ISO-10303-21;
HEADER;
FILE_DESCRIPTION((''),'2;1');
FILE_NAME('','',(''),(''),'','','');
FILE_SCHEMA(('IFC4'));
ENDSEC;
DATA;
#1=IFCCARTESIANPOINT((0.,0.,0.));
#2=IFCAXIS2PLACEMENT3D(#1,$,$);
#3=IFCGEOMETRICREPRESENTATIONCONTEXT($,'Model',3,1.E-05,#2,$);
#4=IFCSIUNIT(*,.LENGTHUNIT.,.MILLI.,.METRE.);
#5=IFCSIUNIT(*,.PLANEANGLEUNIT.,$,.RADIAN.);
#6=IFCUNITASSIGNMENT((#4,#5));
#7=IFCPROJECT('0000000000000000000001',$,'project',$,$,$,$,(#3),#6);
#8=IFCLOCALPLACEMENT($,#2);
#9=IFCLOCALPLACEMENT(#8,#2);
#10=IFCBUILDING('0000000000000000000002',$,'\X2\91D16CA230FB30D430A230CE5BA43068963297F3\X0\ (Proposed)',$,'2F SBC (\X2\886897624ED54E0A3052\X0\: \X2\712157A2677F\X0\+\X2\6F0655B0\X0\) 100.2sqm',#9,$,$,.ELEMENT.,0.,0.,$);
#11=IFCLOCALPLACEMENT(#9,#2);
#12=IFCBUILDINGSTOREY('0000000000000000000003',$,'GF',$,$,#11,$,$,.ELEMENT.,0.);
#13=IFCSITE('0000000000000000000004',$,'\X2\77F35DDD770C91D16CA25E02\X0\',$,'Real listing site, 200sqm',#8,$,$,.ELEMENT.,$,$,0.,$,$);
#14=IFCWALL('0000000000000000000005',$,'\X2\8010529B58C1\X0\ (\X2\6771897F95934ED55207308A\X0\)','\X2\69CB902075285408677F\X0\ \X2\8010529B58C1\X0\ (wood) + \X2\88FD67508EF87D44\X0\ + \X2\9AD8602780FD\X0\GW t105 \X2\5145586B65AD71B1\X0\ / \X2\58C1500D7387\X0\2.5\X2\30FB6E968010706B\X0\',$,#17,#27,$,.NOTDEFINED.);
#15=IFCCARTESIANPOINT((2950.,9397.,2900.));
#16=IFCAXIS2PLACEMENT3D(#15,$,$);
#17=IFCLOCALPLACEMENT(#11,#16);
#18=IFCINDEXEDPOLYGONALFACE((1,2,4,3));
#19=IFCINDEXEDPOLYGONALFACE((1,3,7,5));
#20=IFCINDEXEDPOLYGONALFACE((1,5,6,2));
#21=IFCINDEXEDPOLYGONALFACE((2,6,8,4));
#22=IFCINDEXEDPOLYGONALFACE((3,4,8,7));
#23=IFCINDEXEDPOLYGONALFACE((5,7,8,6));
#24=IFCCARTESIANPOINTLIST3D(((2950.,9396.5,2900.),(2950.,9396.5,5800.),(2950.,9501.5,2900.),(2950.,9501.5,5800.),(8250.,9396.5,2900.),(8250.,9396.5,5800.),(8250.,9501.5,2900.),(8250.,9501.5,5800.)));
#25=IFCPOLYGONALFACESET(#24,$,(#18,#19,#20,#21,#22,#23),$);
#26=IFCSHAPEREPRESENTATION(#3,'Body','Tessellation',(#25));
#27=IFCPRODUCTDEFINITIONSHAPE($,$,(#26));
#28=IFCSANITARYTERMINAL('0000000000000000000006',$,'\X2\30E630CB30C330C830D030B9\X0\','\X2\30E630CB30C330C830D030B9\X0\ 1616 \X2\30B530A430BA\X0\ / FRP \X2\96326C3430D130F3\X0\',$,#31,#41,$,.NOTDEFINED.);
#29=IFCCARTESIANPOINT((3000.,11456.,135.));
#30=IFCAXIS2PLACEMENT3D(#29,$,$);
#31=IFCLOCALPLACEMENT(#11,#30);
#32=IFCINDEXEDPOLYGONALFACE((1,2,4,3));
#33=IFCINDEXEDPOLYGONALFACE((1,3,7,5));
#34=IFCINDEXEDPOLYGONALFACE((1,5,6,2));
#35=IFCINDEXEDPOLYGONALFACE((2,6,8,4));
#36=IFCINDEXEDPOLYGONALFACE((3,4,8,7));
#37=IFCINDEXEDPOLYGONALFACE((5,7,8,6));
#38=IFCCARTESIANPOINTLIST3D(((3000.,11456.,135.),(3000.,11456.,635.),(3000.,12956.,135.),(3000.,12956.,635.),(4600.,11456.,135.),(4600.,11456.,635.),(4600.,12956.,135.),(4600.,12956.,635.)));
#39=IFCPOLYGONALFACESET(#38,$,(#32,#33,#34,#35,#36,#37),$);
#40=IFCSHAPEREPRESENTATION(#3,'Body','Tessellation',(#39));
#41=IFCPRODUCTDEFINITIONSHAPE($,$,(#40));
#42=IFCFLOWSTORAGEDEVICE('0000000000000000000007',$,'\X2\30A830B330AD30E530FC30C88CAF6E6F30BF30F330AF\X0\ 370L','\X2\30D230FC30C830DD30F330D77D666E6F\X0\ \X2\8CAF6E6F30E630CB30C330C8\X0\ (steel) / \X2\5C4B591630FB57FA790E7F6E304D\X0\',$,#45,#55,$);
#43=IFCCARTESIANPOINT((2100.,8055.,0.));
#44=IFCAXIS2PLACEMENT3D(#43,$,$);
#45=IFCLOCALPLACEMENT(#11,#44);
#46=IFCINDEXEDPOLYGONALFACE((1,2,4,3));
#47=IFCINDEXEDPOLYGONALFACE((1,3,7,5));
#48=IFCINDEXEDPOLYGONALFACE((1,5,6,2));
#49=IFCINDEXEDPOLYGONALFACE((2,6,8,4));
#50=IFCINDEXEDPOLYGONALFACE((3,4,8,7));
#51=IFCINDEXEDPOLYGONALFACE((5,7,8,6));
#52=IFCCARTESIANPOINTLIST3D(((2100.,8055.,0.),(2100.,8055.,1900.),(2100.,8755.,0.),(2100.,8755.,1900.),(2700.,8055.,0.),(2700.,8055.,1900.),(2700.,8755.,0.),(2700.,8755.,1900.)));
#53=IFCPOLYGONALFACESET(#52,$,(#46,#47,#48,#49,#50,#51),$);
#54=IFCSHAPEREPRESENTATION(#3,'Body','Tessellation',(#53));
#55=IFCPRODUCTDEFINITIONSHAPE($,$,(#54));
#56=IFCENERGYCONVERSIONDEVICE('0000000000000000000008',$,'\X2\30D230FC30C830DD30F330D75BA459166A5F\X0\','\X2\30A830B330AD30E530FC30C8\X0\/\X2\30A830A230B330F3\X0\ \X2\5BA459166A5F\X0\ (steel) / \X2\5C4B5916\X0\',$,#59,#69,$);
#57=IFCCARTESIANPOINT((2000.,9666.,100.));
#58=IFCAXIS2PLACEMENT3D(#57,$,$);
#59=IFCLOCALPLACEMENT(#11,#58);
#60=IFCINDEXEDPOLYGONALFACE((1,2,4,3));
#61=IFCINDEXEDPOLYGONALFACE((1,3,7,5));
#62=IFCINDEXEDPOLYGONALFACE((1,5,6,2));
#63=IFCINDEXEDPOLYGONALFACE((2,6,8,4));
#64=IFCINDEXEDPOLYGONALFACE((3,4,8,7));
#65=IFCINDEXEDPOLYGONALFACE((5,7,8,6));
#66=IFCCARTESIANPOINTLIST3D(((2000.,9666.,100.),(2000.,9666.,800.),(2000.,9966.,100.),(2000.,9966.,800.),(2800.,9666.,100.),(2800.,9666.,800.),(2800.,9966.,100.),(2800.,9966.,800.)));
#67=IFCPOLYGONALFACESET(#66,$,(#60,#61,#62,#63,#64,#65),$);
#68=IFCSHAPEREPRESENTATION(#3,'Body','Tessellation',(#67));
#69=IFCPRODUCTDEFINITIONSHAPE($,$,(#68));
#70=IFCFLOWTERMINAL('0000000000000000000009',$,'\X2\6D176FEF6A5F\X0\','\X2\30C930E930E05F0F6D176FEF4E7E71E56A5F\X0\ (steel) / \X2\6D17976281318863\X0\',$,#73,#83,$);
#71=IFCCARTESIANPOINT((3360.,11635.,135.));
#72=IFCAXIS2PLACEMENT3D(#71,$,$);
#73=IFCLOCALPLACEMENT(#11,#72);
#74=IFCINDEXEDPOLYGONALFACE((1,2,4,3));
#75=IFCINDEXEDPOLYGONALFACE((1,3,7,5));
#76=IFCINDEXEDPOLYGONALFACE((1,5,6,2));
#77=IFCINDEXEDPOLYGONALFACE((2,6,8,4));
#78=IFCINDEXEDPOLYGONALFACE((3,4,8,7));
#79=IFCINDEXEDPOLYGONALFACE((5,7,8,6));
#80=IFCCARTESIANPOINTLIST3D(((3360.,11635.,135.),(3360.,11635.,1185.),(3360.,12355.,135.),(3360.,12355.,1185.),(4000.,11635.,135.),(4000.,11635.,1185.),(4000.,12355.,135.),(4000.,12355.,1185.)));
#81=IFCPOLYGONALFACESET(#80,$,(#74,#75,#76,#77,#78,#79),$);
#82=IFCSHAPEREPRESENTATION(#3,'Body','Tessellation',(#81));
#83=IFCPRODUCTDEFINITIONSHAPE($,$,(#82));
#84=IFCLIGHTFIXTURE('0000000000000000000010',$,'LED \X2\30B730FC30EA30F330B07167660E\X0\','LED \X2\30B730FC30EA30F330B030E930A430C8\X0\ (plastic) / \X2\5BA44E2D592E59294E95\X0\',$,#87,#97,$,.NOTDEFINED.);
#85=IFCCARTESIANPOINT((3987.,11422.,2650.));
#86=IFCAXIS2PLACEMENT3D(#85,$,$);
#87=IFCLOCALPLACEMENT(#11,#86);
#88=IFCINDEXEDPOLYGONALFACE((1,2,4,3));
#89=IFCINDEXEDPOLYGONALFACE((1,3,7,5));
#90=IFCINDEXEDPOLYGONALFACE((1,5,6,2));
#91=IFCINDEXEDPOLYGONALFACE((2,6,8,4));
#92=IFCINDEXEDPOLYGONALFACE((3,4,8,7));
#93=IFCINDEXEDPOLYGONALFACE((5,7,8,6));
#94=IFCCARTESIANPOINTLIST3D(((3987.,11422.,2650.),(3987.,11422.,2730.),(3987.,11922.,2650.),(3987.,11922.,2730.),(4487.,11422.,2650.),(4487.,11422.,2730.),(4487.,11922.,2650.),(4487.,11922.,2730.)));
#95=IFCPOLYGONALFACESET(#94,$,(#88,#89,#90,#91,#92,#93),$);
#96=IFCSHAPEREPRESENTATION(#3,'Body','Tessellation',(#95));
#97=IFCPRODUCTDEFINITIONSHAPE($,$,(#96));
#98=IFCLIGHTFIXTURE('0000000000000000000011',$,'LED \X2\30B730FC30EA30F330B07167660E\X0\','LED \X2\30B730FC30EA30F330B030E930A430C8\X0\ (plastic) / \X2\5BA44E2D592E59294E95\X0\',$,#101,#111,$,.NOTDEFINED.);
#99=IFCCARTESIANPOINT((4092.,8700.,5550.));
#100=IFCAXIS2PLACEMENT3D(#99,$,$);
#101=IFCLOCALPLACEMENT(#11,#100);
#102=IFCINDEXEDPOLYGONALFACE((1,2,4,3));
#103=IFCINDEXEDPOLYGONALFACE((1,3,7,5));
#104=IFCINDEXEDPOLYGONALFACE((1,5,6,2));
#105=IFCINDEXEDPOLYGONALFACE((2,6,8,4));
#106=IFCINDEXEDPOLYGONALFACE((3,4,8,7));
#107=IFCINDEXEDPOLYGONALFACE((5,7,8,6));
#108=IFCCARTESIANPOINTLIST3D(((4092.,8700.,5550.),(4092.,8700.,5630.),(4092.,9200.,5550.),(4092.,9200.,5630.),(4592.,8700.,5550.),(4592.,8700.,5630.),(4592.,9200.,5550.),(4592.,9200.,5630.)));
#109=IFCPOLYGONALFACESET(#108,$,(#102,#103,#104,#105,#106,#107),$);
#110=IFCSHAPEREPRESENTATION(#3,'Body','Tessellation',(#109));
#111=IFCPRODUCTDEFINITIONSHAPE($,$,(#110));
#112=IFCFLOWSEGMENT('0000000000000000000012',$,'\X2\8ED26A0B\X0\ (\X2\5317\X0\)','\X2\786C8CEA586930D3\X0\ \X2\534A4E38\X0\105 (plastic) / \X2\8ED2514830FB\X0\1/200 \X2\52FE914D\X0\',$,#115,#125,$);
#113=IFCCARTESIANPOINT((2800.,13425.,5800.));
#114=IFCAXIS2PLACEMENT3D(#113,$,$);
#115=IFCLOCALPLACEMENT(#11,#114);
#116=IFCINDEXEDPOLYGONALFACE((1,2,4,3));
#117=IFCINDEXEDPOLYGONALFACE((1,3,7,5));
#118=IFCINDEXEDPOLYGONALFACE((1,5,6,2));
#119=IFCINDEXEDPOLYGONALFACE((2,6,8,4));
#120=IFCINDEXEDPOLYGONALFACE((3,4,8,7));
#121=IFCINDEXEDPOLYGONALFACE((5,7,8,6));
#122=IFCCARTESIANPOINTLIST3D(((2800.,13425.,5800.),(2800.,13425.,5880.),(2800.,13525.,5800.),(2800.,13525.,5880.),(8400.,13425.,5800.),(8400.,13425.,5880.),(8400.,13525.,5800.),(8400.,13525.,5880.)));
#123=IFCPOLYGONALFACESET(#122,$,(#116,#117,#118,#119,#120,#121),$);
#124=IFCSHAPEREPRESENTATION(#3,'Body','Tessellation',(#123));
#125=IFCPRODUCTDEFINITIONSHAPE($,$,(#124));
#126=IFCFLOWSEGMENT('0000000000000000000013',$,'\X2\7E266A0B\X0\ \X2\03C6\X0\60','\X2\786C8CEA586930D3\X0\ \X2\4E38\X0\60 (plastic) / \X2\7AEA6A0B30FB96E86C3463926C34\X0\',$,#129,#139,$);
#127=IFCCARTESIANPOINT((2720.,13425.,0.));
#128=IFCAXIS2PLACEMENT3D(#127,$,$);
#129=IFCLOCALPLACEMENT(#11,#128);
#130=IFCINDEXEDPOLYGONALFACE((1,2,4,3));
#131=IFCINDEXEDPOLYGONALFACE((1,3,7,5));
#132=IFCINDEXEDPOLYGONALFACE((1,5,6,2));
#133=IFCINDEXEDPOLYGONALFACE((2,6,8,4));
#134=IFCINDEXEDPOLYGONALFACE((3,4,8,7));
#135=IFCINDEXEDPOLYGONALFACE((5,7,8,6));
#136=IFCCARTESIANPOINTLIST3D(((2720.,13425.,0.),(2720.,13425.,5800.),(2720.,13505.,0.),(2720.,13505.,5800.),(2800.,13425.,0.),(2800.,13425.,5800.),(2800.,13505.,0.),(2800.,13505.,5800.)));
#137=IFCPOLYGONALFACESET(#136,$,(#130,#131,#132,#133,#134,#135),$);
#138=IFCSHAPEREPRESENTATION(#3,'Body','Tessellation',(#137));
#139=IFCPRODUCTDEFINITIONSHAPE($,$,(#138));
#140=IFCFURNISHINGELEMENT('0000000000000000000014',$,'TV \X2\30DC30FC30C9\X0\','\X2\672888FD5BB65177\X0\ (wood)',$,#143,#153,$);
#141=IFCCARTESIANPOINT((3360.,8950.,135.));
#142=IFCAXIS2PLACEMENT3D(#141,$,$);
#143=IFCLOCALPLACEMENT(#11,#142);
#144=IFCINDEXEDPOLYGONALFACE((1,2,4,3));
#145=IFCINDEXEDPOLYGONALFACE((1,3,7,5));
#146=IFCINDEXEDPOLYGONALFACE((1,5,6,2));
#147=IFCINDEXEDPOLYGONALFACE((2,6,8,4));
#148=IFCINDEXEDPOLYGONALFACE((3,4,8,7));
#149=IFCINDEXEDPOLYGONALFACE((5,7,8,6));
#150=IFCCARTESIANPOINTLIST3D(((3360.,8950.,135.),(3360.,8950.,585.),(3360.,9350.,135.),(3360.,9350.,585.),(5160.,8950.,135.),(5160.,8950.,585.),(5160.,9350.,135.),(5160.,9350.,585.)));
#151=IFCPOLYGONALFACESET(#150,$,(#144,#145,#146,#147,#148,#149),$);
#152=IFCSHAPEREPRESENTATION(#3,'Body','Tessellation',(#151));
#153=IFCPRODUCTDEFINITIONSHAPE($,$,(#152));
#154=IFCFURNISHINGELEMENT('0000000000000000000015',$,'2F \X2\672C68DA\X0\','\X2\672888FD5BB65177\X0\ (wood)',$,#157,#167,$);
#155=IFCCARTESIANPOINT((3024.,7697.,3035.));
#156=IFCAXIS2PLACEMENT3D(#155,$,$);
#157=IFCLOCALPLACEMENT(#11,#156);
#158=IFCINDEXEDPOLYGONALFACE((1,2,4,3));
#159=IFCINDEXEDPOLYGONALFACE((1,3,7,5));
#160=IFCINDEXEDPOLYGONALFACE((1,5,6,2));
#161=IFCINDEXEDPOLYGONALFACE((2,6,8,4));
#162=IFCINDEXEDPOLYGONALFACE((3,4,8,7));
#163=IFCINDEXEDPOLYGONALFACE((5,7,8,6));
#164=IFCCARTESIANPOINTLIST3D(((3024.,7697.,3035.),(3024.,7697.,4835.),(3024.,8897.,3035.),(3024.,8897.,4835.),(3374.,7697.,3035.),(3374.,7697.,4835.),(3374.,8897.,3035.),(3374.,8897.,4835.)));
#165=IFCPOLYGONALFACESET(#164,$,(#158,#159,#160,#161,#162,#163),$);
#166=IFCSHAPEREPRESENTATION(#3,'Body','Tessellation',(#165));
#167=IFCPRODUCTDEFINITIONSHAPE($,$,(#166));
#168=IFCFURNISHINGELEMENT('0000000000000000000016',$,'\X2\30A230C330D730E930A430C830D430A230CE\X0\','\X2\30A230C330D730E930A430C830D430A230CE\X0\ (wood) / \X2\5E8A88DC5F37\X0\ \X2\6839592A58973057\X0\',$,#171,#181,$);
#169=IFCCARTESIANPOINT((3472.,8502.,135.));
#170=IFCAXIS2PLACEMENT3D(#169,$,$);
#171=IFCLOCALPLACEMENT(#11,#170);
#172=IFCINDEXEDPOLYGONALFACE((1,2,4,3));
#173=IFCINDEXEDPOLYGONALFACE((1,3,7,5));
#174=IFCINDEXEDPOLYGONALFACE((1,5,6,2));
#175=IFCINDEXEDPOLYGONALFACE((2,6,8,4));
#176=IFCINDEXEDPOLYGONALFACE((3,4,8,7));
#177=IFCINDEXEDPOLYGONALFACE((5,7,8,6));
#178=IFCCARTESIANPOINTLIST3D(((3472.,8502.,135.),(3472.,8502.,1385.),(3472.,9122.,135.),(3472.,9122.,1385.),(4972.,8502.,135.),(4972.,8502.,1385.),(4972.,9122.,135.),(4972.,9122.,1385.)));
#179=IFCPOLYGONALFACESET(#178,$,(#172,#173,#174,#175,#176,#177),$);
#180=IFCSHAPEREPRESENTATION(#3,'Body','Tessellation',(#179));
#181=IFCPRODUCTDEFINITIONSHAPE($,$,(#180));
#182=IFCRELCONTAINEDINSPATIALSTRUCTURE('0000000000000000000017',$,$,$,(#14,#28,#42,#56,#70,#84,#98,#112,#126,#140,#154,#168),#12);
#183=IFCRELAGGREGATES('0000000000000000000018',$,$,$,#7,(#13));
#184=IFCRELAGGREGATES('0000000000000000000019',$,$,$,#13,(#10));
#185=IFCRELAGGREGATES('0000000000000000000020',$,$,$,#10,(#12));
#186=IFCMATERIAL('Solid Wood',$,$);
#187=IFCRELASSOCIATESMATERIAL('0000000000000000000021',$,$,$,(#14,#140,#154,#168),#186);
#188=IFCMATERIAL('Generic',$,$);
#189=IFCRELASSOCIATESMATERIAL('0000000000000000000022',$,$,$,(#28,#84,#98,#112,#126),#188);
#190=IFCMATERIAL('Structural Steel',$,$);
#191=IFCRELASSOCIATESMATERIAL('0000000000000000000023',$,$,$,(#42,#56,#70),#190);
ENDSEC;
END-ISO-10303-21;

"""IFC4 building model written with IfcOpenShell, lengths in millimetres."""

from ifc_helpers import new_model, si_unit, frame, frame_2d, origin, place, context, project, spatial, rectangle, extrude, material, element, save


model = new_model("IFC4")

# Units and contexts
model_context = context("Model", 3, precision=1e-05, world=origin())
ifc_project = project(units=[si_unit("LENGTHUNIT", "METRE", prefix="MILLI"), si_unit("PLANEANGLEUNIT", "RADIAN")], contexts=[model_context])

# Site, building, storey
site_placement = place(None, origin())
site = spatial("IfcSite", under=ifc_project, at=site_placement, Name="石川県金沢市", ObjectType="Real listing site, 200sqm", CompositionType="ELEMENT", RefElevation=0.0)
building_placement = place(site_placement, origin())
building = spatial("IfcBuilding", under=site, at=building_placement, Name="金沢・ピアノ室と防音 (Proposed)", ObjectType="2F SBC (表面仕上げ: 無垢板+漆喰) 100.2sqm", CompositionType="ELEMENT", ElevationOfRefHeight=0.0, ElevationOfTerrain=0.0)
storey_placement = place(building_placement, origin())
storey = spatial("IfcBuildingStorey", under=building, at=storey_placement, Name="GF", CompositionType="ELEMENT", Elevation=0.0)

# Shared definitions
ifc_material_1 = material(Name="Solid Wood")

# Wall
wall_1_placement = place(storey_placement, frame((2950.0, 9397.0, 2900.0)))
element("IfcWall", 1, at=wall_1_placement, inside=storey, material=ifc_material_1, Name="耐力壁 (東西間仕切り)", Description="構造用合板 耐力壁 (wood) + 製材軸組 + 高性能GW t105 充填断熱 / 壁倍率2.5・準耐火", PredefinedType="NOTDEFINED", context=model_context, shape_type="SweptSolid", body=[
    extrude(rectangle(XDim=5300.0, YDim=105.0, at=frame_2d((2650.0, 52.0))), frame((2950.0, 9397.0, 2900.0)), (0.0, 0.0, 1.0), 2900.0),
])

# Sanitary terminal
ifc_material_2 = material(Name="Generic")
sanitary_terminal_placement = place(storey_placement, frame((3000.0, 11456.0, 135.0)))
element("IfcSanitaryTerminal", 2, at=sanitary_terminal_placement, inside=storey, material=ifc_material_2, Name="ユニットバス", Description="ユニットバス 1616 サイズ / FRP 防水パン", PredefinedType="NOTDEFINED", context=model_context, shape_type="SweptSolid", body=[
    extrude(rectangle(XDim=1600.0, YDim=1500.0, at=frame_2d((800.0, 750.0))), frame((3000.0, 11456.0, 135.0)), (0.0, 0.0, 1.0), 500.0),
])

# Flow storage device
ifc_material_3 = material(Name="Structural Steel")
flow_storage_device_placement = place(storey_placement, frame((2100.0, 8055.0, 0.0)))
element("IfcFlowStorageDevice", 3, at=flow_storage_device_placement, inside=storey, material=ifc_material_3, Name="エコキュート貯湯タンク 370L", Description="ヒートポンプ給湯 貯湯ユニット (steel) / 屋外・基礎置き", context=model_context, shape_type="SweptSolid", body=[
    extrude(rectangle(XDim=600.0, YDim=700.0, at=frame_2d((300.0, 350.0))), frame((2100.0, 8055.0, 0.0)), (0.0, 0.0, 1.0), 1900.0),
])

# Energy conversion device
energy_conversion_device_placement = place(storey_placement, frame((2000.0, 9666.0, 100.0)))
element("IfcEnergyConversionDevice", 4, at=energy_conversion_device_placement, inside=storey, material=ifc_material_3, Name="ヒートポンプ室外機", Description="エコキュート/エアコン 室外機 (steel) / 屋外", context=model_context, shape_type="SweptSolid", body=[
    extrude(rectangle(XDim=800.0, YDim=300.0, at=frame_2d((400.0, 150.0))), frame((2000.0, 9666.0, 100.0)), (0.0, 0.0, 1.0), 700.0),
])

# Flow terminal
flow_terminal_placement = place(storey_placement, frame((3360.0, 11635.0, 135.0)))
element("IfcFlowTerminal", 5, at=flow_terminal_placement, inside=storey, material=ifc_material_3, Name="洗濯機", Description="ドラム式洗濯乾燥機 (steel) / 洗面脱衣", context=model_context, shape_type="SweptSolid", body=[
    extrude(rectangle(XDim=640.0, YDim=720.0, at=frame_2d((320.0, 360.0))), frame((3360.0, 11635.0, 135.0)), (0.0, 0.0, 1.0), 1050.0),
])

# Light fixtures
light_fixture_1_placement = place(storey_placement, frame((3987.0, 11422.0, 2650.0)))
element("IfcLightFixture", 6, at=light_fixture_1_placement, inside=storey, material=ifc_material_2, Name="LED シーリング照明", Description="LED シーリングライト (plastic) / 室中央天井", PredefinedType="NOTDEFINED", context=model_context, shape_type="SweptSolid", body=[
    extrude(rectangle(XDim=500.0, YDim=500.0, at=frame_2d((250.0, 250.0))), frame((3987.0, 11422.0, 2650.0)), (0.0, 0.0, 1.0), 80.0),
])
light_fixture_2_placement = place(storey_placement, frame((4092.0, 8700.0, 5550.0)))
element("IfcLightFixture", 7, at=light_fixture_2_placement, inside=storey, material=ifc_material_2, Name="LED シーリング照明", Description="LED シーリングライト (plastic) / 室中央天井", PredefinedType="NOTDEFINED", context=model_context, shape_type="SweptSolid", body=[
    extrude(rectangle(XDim=500.0, YDim=500.0, at=frame_2d((250.0, 250.0))), frame((4092.0, 8700.0, 5550.0)), (0.0, 0.0, 1.0), 80.0),
])

# Flow segments
flow_segment_1_placement = place(storey_placement, frame((2800.0, 13425.0, 5800.0)))
element("IfcFlowSegment", 8, at=flow_segment_1_placement, inside=storey, material=ifc_material_2, Name="軒樋 (北)", Description="硬質塩ビ 半丸105 (plastic) / 軒先・1/200 勾配", context=model_context, shape_type="SweptSolid", body=[
    extrude(rectangle(XDim=5600.0, YDim=100.0, at=frame_2d((2800.0, 50.0))), frame((2800.0, 13425.0, 5800.0)), (0.0, 0.0, 1.0), 80.0),
])
flow_segment_2_placement = place(storey_placement, frame((2720.0, 13425.0, 0.0)))
element("IfcFlowSegment", 9, at=flow_segment_2_placement, inside=storey, material=ifc_material_2, Name="縦樋 φ60", Description="硬質塩ビ 丸60 (plastic) / 竪樋・雨水排水", context=model_context, shape_type="SweptSolid", body=[
    extrude(rectangle(XDim=80.0, YDim=80.0, at=frame_2d((40.0, 40.0))), frame((2720.0, 13425.0, 0.0)), (0.0, 0.0, 1.0), 5800.0),
])

# Furnishing elements
furnishing_1_placement = place(storey_placement, frame((3360.0, 8950.0, 135.0)))
element("IfcFurnishingElement", 10, at=furnishing_1_placement, inside=storey, material=ifc_material_1, Name="TV ボード", Description="木製家具 (wood)", context=model_context, shape_type="SweptSolid", body=[
    extrude(rectangle(XDim=1800.0, YDim=400.0, at=frame_2d((900.0, 200.0))), frame((3360.0, 8950.0, 135.0)), (0.0, 0.0, 1.0), 450.0),
])
furnishing_2_placement = place(storey_placement, frame((3024.0, 7697.0, 3035.0)))
element("IfcFurnishingElement", 11, at=furnishing_2_placement, inside=storey, material=ifc_material_1, Name="2F 本棚", Description="木製家具 (wood)", context=model_context, shape_type="SweptSolid", body=[
    extrude(rectangle(XDim=350.0, YDim=1200.0, at=frame_2d((175.0, 600.0))), frame((3024.0, 7697.0, 3035.0)), (0.0, 0.0, 1.0), 1800.0),
])
furnishing_3_placement = place(storey_placement, frame((3472.0, 8502.0, 135.0)))
element("IfcFurnishingElement", 12, at=furnishing_3_placement, inside=storey, material=ifc_material_1, Name="アップライトピアノ", Description="アップライトピアノ (wood) / 床補強 根太増し", context=model_context, shape_type="SweptSolid", body=[
    extrude(rectangle(XDim=1500.0, YDim=620.0, at=frame_2d((750.0, 310.0))), frame((3472.0, 8502.0, 135.0)), (0.0, 0.0, 1.0), 1250.0),
])

save(model, "model.ifc")
